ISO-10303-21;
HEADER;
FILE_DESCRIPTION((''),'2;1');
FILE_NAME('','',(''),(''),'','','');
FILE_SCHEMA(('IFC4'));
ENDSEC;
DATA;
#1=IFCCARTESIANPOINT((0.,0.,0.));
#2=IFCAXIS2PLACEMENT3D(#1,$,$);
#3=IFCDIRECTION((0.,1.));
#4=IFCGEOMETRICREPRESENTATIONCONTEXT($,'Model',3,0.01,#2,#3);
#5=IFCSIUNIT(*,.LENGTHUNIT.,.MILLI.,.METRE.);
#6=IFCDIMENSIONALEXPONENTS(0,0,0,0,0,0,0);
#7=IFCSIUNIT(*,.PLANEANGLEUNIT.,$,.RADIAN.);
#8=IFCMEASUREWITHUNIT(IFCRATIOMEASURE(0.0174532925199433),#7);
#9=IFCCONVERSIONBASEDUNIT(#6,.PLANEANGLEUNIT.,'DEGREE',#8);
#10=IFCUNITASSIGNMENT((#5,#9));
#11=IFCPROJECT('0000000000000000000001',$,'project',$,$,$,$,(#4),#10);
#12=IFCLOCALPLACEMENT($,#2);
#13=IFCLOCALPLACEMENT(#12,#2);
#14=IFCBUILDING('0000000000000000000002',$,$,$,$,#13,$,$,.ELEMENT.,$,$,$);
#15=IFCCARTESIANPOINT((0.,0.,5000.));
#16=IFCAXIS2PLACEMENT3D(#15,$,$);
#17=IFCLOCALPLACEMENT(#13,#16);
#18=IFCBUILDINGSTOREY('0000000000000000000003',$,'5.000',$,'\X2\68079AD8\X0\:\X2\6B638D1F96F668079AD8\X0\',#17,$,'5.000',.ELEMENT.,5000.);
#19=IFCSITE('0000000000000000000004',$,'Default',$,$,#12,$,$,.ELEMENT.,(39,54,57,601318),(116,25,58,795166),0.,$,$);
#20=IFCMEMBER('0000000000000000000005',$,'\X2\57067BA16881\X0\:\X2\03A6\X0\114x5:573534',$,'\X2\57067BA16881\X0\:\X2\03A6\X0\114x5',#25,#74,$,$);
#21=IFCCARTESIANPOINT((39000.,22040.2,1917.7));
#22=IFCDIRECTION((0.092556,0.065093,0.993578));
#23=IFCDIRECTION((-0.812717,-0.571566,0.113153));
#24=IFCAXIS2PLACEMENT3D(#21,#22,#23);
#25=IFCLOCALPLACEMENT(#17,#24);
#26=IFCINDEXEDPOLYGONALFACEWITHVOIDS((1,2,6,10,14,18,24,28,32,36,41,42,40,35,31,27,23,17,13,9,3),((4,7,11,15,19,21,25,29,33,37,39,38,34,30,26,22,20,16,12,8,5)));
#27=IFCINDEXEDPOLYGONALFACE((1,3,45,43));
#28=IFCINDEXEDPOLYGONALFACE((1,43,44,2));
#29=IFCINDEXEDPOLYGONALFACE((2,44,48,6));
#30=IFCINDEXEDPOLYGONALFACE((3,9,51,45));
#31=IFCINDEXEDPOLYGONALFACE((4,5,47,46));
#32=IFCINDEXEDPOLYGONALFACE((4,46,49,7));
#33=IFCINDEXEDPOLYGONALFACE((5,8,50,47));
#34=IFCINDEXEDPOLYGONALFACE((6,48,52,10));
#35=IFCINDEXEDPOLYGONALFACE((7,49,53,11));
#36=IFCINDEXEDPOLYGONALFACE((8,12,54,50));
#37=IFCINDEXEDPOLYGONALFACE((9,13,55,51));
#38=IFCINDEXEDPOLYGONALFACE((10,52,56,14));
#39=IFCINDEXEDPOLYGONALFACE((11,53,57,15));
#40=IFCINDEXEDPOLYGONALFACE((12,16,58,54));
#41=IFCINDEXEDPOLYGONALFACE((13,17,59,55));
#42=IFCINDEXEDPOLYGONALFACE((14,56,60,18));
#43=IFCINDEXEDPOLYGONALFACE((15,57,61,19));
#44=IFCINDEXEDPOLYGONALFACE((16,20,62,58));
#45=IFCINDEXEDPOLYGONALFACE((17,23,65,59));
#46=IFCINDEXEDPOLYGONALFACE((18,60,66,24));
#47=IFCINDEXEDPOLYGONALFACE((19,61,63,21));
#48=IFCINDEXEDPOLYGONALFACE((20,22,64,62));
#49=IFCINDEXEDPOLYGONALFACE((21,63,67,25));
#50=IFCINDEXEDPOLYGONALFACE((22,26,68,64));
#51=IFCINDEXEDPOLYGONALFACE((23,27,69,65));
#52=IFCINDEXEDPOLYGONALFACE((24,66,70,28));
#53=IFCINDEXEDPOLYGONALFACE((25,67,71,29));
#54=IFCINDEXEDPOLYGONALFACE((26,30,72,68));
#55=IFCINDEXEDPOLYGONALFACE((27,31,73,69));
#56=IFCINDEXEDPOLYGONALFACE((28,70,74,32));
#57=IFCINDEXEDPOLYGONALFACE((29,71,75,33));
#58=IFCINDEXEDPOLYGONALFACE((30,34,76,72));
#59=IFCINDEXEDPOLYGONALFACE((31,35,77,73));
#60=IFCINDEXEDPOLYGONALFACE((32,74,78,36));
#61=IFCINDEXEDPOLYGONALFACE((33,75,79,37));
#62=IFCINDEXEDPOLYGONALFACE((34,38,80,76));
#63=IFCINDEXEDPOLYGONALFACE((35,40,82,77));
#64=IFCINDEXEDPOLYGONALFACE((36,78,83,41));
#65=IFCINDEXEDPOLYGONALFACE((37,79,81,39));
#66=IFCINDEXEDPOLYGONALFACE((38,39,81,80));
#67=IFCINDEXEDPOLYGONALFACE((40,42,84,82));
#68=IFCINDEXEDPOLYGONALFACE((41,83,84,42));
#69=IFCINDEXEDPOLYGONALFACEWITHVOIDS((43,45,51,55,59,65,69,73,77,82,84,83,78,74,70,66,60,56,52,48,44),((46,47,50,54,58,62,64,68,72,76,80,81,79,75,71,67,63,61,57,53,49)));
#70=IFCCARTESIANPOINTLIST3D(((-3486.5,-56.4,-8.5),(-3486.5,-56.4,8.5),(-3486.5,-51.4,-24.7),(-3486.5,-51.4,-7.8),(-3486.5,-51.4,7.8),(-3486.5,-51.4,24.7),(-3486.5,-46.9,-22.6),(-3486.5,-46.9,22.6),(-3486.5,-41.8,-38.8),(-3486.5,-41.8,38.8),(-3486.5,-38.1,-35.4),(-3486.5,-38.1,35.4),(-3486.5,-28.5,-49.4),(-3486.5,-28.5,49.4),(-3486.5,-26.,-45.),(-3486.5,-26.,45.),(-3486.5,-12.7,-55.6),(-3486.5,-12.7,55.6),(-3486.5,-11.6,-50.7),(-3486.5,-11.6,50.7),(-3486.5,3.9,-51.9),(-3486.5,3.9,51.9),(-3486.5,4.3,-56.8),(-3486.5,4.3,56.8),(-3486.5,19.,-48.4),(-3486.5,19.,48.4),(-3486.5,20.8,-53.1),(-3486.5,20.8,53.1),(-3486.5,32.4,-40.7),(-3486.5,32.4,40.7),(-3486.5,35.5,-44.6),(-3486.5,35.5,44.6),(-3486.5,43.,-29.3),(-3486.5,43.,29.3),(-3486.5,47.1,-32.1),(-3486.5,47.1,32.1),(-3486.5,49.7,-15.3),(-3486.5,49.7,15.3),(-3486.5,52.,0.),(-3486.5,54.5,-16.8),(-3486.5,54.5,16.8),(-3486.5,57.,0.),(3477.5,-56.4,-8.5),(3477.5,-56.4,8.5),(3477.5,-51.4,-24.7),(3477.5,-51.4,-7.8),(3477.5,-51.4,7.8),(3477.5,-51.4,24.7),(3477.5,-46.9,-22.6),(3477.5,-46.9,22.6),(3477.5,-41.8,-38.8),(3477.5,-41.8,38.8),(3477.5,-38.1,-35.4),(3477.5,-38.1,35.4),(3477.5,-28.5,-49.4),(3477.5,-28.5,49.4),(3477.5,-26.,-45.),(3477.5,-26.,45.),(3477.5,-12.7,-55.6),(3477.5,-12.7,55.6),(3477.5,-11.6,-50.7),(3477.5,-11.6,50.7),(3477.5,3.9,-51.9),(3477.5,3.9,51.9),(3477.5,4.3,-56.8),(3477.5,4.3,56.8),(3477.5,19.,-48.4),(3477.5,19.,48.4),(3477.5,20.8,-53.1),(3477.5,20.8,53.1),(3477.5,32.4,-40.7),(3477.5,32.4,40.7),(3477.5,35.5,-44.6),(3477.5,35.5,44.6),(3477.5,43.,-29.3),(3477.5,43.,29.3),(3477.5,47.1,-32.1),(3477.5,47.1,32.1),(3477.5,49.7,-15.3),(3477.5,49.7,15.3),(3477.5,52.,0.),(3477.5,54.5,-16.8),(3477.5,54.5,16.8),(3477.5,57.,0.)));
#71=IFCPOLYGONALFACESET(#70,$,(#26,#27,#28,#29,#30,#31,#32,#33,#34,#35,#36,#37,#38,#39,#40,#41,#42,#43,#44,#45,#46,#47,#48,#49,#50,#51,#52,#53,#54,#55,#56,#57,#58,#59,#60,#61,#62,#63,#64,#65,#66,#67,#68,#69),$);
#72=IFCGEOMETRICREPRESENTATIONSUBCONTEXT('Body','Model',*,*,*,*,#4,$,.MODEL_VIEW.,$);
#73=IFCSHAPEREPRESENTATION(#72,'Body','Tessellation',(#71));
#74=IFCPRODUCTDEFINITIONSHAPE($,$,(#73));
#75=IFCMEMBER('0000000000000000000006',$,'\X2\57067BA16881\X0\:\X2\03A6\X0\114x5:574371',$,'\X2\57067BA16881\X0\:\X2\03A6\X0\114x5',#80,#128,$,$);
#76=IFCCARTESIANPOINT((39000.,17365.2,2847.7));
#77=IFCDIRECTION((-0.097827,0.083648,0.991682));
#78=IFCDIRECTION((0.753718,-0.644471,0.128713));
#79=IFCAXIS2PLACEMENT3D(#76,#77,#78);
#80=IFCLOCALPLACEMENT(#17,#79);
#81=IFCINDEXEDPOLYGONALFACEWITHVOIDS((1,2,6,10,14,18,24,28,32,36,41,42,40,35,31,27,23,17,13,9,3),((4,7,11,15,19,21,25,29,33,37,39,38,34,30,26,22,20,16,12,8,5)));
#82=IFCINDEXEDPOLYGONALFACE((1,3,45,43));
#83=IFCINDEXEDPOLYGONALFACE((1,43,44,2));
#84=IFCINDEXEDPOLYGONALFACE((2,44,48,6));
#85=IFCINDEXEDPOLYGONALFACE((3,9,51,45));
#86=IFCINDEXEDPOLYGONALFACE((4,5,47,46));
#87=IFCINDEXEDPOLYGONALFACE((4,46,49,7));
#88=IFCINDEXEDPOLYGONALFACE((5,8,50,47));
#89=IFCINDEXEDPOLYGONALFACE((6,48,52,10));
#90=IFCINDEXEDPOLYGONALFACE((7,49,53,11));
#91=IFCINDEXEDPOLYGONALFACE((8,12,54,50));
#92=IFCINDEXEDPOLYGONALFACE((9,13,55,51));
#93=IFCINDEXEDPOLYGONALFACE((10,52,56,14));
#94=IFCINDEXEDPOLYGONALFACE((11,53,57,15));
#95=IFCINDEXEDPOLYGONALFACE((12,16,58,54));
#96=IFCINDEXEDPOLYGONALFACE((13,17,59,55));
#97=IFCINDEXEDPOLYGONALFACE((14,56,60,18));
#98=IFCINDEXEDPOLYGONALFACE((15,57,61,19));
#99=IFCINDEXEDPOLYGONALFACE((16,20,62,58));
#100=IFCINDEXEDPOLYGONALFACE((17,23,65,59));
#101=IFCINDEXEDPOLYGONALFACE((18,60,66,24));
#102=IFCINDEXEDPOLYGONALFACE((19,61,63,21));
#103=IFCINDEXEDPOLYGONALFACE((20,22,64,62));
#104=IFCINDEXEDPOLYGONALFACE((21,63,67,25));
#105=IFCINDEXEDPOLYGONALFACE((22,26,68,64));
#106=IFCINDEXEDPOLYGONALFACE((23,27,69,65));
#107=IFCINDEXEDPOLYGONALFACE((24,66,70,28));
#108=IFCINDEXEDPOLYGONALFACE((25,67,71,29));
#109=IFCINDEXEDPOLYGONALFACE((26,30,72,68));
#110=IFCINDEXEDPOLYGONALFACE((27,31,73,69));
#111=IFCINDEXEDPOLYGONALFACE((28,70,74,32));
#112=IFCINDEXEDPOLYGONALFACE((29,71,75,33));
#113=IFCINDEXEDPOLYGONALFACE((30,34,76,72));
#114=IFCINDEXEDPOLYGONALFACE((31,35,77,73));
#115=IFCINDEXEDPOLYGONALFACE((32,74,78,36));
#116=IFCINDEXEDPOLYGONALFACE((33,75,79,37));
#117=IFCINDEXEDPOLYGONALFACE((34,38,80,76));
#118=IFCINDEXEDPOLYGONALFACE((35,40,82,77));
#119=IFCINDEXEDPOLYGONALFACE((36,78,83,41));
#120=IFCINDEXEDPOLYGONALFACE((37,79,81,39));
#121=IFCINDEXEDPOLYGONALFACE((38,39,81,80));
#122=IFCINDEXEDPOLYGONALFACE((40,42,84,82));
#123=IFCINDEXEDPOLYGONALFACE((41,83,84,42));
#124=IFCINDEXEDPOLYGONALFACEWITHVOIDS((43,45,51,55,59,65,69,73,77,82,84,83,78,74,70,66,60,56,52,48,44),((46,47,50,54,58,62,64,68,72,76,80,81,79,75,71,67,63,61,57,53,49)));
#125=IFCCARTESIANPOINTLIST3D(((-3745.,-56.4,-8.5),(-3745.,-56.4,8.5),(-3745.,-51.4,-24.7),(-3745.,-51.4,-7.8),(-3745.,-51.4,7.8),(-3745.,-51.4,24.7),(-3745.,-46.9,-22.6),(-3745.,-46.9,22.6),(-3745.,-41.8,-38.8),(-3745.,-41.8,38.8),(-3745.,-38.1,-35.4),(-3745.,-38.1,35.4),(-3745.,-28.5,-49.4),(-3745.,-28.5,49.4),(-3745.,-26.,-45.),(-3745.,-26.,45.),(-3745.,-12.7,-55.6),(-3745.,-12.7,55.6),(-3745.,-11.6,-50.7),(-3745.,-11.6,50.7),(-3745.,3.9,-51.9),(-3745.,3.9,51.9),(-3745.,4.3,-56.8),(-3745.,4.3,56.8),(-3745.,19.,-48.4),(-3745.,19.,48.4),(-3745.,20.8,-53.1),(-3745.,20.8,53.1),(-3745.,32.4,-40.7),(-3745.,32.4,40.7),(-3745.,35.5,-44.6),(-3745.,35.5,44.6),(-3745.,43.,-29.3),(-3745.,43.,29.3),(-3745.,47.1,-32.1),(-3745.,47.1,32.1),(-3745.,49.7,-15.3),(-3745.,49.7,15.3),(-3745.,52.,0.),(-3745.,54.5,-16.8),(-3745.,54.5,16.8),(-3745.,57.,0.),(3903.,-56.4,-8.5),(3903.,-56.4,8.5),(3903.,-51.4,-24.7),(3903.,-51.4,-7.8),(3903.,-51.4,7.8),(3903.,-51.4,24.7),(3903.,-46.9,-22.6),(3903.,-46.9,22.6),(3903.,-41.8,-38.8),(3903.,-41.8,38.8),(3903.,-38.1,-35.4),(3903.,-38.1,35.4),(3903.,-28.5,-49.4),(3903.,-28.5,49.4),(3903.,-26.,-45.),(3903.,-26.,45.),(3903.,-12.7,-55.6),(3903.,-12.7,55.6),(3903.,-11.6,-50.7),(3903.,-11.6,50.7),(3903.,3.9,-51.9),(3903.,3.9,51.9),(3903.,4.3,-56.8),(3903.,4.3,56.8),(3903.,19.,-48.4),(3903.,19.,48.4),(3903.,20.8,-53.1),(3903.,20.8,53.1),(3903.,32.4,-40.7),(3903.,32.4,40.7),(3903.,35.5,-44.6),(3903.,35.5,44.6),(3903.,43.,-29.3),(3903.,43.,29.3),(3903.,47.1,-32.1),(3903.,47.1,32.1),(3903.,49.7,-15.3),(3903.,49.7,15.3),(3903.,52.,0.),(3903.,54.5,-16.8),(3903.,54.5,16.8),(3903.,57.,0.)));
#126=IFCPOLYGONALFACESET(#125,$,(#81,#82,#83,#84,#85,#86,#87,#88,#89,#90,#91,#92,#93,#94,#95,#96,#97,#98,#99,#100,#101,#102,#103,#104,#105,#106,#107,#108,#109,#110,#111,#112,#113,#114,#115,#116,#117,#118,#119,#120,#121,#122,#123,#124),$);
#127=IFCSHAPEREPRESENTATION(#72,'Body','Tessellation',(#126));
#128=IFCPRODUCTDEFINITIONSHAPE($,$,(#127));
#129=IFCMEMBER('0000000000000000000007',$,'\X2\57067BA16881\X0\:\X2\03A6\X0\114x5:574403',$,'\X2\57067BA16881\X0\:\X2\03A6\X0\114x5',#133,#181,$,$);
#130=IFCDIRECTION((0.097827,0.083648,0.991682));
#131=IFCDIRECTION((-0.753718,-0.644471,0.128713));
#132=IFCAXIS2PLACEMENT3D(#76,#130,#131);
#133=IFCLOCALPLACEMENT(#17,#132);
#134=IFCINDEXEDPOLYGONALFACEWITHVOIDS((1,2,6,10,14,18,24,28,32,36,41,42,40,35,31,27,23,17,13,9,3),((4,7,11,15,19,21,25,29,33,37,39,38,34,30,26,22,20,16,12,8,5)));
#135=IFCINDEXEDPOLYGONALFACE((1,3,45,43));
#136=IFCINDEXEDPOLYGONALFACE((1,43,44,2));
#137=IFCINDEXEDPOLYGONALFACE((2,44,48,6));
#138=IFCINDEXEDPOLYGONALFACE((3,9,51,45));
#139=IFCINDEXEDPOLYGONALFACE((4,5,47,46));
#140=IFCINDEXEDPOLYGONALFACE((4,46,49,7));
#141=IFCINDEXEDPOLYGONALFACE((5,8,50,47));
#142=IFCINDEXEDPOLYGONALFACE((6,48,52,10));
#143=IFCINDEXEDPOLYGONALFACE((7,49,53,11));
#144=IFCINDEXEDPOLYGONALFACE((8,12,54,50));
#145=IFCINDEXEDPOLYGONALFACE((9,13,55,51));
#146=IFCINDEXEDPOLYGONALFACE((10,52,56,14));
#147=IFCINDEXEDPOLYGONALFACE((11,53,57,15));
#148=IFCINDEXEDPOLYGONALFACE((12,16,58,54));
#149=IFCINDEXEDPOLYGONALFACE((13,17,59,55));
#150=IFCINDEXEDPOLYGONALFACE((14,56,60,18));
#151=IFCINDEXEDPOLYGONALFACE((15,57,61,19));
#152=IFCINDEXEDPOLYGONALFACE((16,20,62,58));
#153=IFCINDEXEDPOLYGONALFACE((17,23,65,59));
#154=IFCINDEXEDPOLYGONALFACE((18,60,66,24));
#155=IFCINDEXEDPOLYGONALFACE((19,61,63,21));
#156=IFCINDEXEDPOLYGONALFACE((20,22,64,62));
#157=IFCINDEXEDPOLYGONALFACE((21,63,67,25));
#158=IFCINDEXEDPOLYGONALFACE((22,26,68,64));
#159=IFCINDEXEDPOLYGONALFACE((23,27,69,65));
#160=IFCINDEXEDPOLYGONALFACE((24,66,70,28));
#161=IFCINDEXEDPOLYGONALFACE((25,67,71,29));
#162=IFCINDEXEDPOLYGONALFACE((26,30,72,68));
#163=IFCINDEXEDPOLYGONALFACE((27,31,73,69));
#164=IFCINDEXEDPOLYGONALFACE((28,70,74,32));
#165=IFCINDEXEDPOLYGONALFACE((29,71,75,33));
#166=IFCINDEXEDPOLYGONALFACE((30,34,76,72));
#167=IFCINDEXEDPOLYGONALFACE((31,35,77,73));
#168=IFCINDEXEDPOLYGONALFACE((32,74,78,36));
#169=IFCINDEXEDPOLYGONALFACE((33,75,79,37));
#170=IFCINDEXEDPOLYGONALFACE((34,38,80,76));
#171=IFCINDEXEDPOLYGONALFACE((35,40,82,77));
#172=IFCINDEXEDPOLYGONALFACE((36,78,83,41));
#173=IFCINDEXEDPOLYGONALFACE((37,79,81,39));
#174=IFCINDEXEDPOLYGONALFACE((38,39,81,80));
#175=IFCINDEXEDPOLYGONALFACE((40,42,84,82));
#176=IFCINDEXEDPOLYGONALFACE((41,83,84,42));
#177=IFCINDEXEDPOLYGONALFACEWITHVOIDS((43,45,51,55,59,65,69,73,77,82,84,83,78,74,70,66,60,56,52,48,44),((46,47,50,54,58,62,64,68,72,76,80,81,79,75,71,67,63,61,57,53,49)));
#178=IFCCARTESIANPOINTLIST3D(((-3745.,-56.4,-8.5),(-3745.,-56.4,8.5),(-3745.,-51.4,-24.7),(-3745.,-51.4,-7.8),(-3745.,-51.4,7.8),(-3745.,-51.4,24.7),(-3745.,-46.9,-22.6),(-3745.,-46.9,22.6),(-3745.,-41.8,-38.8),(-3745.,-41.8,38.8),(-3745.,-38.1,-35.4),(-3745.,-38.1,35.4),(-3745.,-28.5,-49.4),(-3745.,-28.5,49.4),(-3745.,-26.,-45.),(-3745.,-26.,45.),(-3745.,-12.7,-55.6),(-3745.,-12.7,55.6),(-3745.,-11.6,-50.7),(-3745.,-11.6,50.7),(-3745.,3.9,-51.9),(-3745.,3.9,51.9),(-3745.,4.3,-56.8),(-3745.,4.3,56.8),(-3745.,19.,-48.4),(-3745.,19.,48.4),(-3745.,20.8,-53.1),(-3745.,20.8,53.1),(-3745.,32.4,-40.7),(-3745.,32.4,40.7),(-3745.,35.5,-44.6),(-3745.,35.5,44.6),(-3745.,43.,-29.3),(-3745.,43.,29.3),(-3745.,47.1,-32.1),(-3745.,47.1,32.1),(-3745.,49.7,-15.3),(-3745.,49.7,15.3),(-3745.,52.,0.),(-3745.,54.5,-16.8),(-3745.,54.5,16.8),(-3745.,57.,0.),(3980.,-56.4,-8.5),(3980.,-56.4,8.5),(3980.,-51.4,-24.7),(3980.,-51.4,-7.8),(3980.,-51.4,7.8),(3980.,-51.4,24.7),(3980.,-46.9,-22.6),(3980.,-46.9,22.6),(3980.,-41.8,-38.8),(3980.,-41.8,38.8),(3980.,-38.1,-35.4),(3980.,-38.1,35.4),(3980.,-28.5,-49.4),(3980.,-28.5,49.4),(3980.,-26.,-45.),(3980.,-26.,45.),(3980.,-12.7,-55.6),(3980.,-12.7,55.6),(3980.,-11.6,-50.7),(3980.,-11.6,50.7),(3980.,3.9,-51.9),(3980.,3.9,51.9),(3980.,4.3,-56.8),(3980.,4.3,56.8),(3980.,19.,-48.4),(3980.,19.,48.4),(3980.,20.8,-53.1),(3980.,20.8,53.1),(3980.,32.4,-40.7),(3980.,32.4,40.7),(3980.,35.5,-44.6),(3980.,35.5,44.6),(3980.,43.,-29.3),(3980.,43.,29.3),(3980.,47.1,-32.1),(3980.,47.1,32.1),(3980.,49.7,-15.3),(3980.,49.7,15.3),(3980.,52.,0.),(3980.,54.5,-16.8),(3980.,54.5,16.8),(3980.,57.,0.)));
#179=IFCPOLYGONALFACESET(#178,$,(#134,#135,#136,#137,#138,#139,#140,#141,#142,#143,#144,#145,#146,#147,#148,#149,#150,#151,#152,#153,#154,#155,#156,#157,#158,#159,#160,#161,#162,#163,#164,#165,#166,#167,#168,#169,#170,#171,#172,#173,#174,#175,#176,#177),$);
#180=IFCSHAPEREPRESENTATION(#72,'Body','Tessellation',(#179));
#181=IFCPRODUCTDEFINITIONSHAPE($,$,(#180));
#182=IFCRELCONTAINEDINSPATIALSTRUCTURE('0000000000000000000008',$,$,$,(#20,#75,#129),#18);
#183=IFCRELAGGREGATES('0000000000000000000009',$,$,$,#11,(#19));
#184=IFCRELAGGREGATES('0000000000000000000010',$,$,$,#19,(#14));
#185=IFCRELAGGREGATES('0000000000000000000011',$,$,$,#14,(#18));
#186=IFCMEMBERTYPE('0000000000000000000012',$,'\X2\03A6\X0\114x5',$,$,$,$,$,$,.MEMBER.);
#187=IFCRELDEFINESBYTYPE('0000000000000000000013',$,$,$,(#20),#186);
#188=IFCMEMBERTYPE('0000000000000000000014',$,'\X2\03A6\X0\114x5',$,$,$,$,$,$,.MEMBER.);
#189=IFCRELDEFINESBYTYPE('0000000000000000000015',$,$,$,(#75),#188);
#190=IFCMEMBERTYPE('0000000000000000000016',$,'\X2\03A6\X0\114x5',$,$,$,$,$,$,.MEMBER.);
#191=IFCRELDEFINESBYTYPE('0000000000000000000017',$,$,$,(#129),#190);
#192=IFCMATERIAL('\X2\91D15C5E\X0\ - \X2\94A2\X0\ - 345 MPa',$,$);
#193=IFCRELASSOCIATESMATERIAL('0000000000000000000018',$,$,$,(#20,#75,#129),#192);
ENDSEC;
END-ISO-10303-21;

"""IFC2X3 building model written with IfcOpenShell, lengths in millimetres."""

from ifc_helpers import new_model, entity, si_unit, converted_unit, direction, frame, frame_2d, origin, place, context, subcontext, project, spatial, hollow_circle, extrude, source, transform, mapped, material, type_object, type_shapes, element, save


model = new_model("IFC2X3")

# Units and contexts
model_context = context("Model", 3, precision=0.01, world=origin(), true_north=direction((0.0, 1.0)))
body_context = subcontext(model_context, "Body", "Model", "MODEL_VIEW")
ifc_project = project(units=[si_unit("LENGTHUNIT", "METRE", prefix="MILLI"), converted_unit("PLANEANGLEUNIT", "DEGREE", entity("IfcRatioMeasure", 0.0174532925199433), si_unit("PLANEANGLEUNIT", "RADIAN"), dimensions=[0, 0, 0, 0, 0, 0, 0])], contexts=[model_context])

# Site, building, storey
site_placement = place(None, origin())
site = spatial("IfcSite", under=ifc_project, at=site_placement, Name="Default", CompositionType="ELEMENT", RefLatitude=(39, 54, 57, 601318), RefLongitude=(116, 25, 58, 795166), RefElevation=0.0)
building_placement = place(site_placement, origin())
building = spatial("IfcBuilding", under=site, at=building_placement, CompositionType="ELEMENT")
storey_placement = place(building_placement, frame((0.0, 0.0, 5000.0)))
storey = spatial("IfcBuildingStorey", under=building, at=storey_placement, Name="5.000", ObjectType="标高:正负零标高", LongName="5.000", CompositionType="ELEMENT", Elevation=5000.0)

# Members
ifc_material_1 = material(Name="金属 - 钢 - 345 MPa")
member_type_1 = type_object("IfcMemberType", Name="Φ114x5", PredefinedType="MEMBER")
shared_shape_1 = source(origin(), body_context, "Body", "SweptSolid", [
    extrude(hollow_circle(Radius=57.0, WallThickness=5.0, at=frame_2d((0.0, 0.0), x_axis=(1.0, 0.0))), frame((-3486.5, 0.0, 0.0), z_axis=(1.0, 0.0, 0.0), x_axis=(0.0, 1.0, 0.0)), (0.0, 0.0, 1.0), 6964.0),
])
type_shapes(member_type_1, [shared_shape_1])
for number, where, z_axis, x_axis, name in (
    (1, (39000.0, 22040.2, 1917.7), (0.092556, 0.065093, 0.993578), (-0.812717, -0.571566, 0.113153), "圆管梁:Φ114x5:573534"),
):
    element("IfcMember", number, at=place(storey_placement, frame(where, z_axis=z_axis, x_axis=x_axis)), inside=storey, type_object=member_type_1, material=ifc_material_1, Name=name, ObjectType="圆管梁:Φ114x5", context=body_context, shape_type="MappedRepresentation", body=[
        mapped(shared_shape_1, transform((0.0, 0.0, 0.0), scale=1.0)),
    ])
member_type_2 = type_object("IfcMemberType", Name="Φ114x5", PredefinedType="MEMBER")
shared_shape_2 = source(origin(), body_context, "Body", "SweptSolid", [
    extrude(hollow_circle(Radius=57.0, WallThickness=5.0, at=frame_2d((0.0, 0.0), x_axis=(1.0, 0.0))), frame((-3745.0, 0.0, 0.0), z_axis=(1.0, 0.0, 0.0), x_axis=(0.0, 1.0, 0.0)), (0.0, 0.0, 1.0), 7648.0),
])
type_shapes(member_type_2, [shared_shape_2])
member_1_placement = place(storey_placement, frame((39000.0, 17365.2, 2847.7), z_axis=(-0.097827, 0.083648, 0.991682), x_axis=(0.753718, -0.644471, 0.128713)))
element("IfcMember", 2, at=member_1_placement, inside=storey, type_object=member_type_2, material=ifc_material_1, Name="圆管梁:Φ114x5:574371", ObjectType="圆管梁:Φ114x5", context=body_context, shape_type="MappedRepresentation", body=[
    mapped(shared_shape_2, transform((0.0, 0.0, 0.0), scale=1.0)),
])
member_type_3 = type_object("IfcMemberType", Name="Φ114x5", PredefinedType="MEMBER")
shared_shape_3 = source(origin(), body_context, "Body", "SweptSolid", [
    extrude(hollow_circle(Radius=57.0, WallThickness=5.0, at=frame_2d((0.0, 0.0), x_axis=(1.0, 0.0))), frame((-3745.0, 0.0, 0.0), z_axis=(1.0, 0.0, 0.0), x_axis=(0.0, 1.0, 0.0)), (0.0, 0.0, 1.0), 7725.0),
])
type_shapes(member_type_3, [shared_shape_3])
member_2_placement = place(storey_placement, frame((39000.0, 17365.2, 2847.7), z_axis=(0.097827, 0.083648, 0.991682), x_axis=(-0.753718, -0.644471, 0.128713)))
element("IfcMember", 3, at=member_2_placement, inside=storey, type_object=member_type_3, material=ifc_material_1, Name="圆管梁:Φ114x5:574403", ObjectType="圆管梁:Φ114x5", context=body_context, shape_type="MappedRepresentation", body=[
    mapped(shared_shape_3, transform((0.0, 0.0, 0.0), scale=1.0)),
])

save(model, "model.ifc")
